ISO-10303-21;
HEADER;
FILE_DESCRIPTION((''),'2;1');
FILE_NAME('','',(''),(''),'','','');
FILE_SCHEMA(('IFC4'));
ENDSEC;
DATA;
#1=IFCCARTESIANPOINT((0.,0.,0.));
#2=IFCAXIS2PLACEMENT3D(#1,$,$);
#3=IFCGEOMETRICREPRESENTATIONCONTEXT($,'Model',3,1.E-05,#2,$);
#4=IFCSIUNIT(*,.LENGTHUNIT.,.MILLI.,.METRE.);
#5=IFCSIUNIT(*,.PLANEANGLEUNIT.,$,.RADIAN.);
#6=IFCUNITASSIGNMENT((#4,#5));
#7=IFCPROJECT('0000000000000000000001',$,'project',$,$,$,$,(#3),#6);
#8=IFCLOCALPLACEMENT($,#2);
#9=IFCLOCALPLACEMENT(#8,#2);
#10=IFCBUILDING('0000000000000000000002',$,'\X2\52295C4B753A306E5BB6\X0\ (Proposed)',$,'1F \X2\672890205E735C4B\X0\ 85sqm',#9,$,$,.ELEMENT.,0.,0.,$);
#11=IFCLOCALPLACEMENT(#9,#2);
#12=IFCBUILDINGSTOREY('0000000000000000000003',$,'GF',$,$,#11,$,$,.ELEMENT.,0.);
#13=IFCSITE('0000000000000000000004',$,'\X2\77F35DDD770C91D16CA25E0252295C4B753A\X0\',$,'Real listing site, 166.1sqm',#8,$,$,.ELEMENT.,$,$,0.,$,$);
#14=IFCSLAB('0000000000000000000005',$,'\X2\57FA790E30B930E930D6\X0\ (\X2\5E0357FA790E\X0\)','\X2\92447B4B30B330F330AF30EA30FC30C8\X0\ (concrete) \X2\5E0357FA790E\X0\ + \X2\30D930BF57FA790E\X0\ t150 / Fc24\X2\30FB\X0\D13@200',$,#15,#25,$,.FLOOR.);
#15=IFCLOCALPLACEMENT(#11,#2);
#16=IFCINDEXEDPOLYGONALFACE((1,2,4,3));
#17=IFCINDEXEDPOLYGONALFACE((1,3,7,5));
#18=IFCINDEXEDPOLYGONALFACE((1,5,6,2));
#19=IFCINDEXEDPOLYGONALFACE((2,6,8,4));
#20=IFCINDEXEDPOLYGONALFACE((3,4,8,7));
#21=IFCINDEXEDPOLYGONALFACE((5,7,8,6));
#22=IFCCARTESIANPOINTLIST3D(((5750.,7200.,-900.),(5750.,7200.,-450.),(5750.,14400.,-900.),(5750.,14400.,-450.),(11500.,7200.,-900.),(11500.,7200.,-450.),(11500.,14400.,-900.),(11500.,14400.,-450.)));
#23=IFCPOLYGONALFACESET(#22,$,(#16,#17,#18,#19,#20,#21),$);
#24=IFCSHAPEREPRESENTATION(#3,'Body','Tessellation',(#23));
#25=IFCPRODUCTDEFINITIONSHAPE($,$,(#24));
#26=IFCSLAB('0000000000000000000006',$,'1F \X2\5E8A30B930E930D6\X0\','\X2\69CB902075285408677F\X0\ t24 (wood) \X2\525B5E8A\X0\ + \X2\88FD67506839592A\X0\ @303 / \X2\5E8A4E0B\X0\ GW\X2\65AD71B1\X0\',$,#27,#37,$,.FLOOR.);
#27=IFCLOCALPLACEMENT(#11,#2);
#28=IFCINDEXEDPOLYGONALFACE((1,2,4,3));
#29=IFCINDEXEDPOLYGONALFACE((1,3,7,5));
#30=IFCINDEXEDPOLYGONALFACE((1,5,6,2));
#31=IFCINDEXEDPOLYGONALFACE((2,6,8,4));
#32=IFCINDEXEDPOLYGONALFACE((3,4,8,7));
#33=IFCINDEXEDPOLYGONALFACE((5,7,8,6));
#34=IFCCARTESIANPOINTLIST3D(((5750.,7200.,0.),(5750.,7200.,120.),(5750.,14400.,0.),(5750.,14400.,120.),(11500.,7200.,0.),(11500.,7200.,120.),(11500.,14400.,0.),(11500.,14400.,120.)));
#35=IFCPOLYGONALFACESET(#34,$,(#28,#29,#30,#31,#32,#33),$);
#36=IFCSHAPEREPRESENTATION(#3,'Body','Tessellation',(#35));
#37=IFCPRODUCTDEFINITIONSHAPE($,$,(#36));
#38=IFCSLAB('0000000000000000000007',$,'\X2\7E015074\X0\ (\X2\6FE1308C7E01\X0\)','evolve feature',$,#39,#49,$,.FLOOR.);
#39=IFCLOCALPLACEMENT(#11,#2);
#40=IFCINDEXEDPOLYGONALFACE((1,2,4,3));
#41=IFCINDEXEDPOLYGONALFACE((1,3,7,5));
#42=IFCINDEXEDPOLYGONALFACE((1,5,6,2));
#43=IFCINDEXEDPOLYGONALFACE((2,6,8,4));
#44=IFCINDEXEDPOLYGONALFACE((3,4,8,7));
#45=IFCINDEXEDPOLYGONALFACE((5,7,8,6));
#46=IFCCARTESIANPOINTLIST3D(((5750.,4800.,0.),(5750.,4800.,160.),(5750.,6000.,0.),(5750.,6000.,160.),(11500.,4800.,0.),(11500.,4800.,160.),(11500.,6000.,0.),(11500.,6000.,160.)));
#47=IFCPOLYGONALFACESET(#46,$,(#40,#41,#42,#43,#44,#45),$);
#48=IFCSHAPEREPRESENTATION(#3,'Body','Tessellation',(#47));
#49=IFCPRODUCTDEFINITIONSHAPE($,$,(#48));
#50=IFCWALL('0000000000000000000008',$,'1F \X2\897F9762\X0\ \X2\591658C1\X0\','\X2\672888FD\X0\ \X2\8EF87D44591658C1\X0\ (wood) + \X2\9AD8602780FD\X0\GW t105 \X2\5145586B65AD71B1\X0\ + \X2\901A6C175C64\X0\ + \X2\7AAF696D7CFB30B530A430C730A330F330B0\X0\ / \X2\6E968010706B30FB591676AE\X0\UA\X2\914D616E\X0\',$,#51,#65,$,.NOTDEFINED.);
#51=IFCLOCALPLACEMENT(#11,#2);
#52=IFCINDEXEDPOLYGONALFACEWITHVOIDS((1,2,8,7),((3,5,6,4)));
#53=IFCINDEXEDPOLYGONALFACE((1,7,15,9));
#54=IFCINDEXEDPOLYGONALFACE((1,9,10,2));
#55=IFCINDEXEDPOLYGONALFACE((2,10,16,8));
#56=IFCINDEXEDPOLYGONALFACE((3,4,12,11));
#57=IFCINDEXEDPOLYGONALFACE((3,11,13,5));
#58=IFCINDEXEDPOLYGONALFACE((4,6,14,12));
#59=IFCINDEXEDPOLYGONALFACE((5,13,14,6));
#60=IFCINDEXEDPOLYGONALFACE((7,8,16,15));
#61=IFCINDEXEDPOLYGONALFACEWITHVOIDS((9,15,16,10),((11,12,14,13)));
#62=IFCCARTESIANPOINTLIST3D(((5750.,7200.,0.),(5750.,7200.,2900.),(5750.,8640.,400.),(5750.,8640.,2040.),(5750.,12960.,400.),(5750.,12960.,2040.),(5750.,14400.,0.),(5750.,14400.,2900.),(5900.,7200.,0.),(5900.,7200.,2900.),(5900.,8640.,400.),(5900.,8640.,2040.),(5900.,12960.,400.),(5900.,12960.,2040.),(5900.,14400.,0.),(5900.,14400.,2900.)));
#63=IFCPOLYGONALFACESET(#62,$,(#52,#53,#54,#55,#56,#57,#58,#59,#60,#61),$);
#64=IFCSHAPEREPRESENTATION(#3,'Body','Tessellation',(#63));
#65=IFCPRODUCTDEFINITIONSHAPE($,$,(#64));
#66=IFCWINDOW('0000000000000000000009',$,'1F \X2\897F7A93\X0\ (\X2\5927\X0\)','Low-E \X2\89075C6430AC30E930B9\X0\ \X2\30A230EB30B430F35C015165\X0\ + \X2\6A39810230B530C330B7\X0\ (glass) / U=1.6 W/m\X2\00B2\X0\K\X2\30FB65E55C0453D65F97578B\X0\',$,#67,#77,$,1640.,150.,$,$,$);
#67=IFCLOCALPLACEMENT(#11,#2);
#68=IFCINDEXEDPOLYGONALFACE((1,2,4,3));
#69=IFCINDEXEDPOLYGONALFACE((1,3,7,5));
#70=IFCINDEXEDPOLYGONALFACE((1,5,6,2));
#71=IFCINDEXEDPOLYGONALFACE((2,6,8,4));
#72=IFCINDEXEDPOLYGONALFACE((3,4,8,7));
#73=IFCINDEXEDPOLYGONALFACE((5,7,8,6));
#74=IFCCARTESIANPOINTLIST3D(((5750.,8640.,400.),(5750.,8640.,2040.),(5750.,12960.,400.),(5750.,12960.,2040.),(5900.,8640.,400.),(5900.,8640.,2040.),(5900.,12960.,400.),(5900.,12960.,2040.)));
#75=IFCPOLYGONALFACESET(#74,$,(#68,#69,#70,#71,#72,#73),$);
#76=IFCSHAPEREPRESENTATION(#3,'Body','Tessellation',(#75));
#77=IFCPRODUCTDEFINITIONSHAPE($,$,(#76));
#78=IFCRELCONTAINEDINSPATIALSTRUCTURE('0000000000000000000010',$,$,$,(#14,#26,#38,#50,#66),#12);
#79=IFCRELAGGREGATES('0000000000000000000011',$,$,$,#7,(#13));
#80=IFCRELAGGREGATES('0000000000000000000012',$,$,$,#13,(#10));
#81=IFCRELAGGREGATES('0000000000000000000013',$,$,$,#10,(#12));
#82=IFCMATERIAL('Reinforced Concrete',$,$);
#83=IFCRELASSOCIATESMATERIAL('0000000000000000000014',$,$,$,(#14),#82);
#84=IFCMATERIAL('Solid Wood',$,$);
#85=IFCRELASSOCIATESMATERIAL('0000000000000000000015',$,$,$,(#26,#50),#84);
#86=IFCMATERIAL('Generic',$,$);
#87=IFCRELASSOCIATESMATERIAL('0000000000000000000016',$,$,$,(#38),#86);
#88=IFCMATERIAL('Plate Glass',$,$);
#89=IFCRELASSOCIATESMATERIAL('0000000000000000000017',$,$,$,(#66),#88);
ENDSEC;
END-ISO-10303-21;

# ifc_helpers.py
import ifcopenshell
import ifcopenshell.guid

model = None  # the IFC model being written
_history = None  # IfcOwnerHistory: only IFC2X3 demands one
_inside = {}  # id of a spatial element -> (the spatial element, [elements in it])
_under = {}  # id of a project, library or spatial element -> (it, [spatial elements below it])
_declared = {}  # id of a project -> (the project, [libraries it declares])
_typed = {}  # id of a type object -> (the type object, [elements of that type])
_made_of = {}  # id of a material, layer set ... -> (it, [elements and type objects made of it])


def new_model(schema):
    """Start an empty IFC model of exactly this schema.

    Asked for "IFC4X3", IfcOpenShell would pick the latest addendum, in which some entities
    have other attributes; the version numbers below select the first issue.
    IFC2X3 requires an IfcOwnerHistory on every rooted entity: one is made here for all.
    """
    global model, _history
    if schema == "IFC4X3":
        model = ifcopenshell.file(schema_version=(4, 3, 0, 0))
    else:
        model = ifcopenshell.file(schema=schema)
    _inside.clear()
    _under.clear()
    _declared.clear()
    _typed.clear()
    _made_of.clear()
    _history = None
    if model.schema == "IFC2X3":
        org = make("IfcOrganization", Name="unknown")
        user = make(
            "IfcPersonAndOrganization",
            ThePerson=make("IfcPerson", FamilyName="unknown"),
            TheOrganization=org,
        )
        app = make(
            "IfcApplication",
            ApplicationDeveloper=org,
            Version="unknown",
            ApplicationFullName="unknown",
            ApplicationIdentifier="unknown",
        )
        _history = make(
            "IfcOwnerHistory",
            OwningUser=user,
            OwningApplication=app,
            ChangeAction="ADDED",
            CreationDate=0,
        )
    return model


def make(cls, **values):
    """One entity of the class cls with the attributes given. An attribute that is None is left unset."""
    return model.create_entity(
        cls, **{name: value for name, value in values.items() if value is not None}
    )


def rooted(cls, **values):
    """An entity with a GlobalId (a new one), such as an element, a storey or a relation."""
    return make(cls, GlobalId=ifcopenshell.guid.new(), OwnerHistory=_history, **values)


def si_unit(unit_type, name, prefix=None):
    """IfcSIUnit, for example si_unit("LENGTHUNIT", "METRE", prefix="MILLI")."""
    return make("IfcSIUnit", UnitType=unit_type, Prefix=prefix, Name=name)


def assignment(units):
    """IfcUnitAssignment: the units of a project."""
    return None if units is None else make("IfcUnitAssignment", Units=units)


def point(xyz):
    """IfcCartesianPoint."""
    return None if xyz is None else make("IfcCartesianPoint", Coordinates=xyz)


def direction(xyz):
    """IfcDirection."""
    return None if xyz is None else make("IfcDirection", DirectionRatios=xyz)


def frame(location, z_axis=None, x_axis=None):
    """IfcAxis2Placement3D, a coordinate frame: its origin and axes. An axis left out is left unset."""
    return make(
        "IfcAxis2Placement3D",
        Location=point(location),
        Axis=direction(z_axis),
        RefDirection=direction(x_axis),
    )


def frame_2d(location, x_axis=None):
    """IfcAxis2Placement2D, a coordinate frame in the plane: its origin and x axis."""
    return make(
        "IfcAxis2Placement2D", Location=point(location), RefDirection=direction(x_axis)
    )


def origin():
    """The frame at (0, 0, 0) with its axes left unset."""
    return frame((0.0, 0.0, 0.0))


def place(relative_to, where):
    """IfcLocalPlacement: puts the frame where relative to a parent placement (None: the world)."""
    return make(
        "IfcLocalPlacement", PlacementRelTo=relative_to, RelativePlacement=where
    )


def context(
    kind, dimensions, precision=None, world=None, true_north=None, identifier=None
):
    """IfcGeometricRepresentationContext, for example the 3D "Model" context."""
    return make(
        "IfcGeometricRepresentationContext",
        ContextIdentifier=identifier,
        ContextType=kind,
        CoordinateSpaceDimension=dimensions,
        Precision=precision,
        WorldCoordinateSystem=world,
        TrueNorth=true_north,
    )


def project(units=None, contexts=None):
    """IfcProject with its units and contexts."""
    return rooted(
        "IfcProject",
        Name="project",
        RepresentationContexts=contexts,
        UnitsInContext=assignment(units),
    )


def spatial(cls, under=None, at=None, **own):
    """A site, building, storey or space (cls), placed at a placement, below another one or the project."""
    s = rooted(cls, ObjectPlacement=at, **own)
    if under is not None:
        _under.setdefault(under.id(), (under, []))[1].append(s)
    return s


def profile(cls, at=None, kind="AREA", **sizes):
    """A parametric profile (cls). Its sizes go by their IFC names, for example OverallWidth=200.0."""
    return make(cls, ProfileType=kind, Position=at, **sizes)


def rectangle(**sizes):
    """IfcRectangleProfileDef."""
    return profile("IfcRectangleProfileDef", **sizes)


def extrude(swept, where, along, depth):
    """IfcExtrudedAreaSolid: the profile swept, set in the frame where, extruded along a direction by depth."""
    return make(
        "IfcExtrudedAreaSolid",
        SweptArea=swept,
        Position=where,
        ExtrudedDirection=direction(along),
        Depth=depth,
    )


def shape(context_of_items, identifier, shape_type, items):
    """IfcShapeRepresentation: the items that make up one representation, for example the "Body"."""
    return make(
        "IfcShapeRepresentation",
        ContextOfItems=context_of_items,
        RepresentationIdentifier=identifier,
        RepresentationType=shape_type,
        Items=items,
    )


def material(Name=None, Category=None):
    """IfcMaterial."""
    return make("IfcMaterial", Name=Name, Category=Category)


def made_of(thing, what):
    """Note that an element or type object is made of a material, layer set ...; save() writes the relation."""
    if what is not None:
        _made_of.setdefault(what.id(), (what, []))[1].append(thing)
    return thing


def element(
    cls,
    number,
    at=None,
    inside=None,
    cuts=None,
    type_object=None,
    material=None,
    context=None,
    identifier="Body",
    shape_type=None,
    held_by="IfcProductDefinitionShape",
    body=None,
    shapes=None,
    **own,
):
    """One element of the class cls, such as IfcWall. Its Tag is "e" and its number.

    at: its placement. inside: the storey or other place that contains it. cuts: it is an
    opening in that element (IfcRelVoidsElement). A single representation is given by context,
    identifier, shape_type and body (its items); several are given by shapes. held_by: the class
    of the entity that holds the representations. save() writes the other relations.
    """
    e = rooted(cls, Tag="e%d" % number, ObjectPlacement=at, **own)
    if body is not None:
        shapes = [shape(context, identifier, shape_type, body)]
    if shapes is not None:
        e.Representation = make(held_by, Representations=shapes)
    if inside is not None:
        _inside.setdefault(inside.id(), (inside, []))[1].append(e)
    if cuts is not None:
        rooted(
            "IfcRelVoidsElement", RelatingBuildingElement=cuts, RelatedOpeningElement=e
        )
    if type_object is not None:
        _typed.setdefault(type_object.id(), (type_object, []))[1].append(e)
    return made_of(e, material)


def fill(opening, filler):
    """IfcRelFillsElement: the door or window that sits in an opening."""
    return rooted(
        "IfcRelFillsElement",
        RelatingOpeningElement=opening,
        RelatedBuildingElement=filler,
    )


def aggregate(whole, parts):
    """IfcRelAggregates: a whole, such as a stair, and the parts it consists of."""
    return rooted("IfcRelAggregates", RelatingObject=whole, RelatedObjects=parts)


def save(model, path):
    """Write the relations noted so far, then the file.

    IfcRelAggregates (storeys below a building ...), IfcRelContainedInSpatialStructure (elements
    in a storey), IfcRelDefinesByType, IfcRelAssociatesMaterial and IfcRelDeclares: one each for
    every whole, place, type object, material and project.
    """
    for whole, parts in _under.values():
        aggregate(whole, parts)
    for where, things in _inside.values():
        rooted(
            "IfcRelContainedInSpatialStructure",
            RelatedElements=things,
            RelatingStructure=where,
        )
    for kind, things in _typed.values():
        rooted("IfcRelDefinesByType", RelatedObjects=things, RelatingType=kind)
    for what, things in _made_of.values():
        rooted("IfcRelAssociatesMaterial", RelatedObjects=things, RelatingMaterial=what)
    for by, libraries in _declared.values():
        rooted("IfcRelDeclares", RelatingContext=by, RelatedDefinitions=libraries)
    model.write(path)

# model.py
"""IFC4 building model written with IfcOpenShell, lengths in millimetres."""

from ifc_helpers import new_model, si_unit, frame, frame_2d, origin, place, context, project, spatial, rectangle, extrude, material, element, fill, save


model = new_model("IFC4")

# Units and contexts
model_context = context("Model", 3, precision=1e-05, world=origin())
ifc_project = project(units=[si_unit("LENGTHUNIT", "METRE", prefix="MILLI"), si_unit("PLANEANGLEUNIT", "RADIAN")], contexts=[model_context])

# Site, building, storey
site_placement = place(None, origin())
site = spatial("IfcSite", under=ifc_project, at=site_placement, Name="石川県金沢市利屋町", ObjectType="Real listing site, 166.1sqm", CompositionType="ELEMENT", RefElevation=0.0)
building_placement = place(site_placement, origin())
building = spatial("IfcBuilding", under=site, at=building_placement, Name="利屋町の家 (Proposed)", ObjectType="1F 木造平屋 85sqm", CompositionType="ELEMENT", ElevationOfRefHeight=0.0, ElevationOfTerrain=0.0)
storey_placement = place(building_placement, origin())
storey = spatial("IfcBuildingStorey", under=building, at=storey_placement, Name="GF", CompositionType="ELEMENT", Elevation=0.0)

# Slabs
ifc_material_1 = material(Name="Reinforced Concrete")
slab_1_placement = place(storey_placement, frame((2875.0, 3600.0, -450.0)))
element("IfcSlab", 1, at=slab_1_placement, inside=storey, material=ifc_material_1, Name="基礎スラブ (布基礎)", Description="鉄筋コンクリート (concrete) 布基礎 + ベタ基礎 t150 / Fc24・D13@200", PredefinedType="FLOOR", context=model_context, shape_type="SweptSolid", body=[
    extrude(rectangle(XDim=5750.0, YDim=7200.0, at=frame_2d((2875.0, 3600.0))), frame((2875.0, 3600.0, -450.0)), (0.0, 0.0, 1.0), 450.0),
])
ifc_material_2 = material(Name="Solid Wood")
slab_2_placement = place(storey_placement, frame((2875.0, 3600.0, 0.0)))
element("IfcSlab", 2, at=slab_2_placement, inside=storey, material=ifc_material_2, Name="1F 床スラブ", Description="構造用合板 t24 (wood) 剛床 + 製材根太 @303 / 床下 GW断熱", PredefinedType="FLOOR", context=model_context, shape_type="SweptSolid", body=[
    extrude(rectangle(XDim=5750.0, YDim=7200.0, at=frame_2d((2875.0, 3600.0))), frame((2875.0, 3600.0, 0.0)), (0.0, 0.0, 1.0), 120.0),
])
ifc_material_3 = material(Name="Generic")
slab_3_placement = place(storey_placement, frame((2875.0, 2400.0, 0.0)))
element("IfcSlab", 3, at=slab_3_placement, inside=storey, material=ifc_material_3, Name="縁側 (濡れ縁)", Description="evolve feature", PredefinedType="FLOOR", context=model_context, shape_type="SweptSolid", body=[
    extrude(rectangle(XDim=5750.0, YDim=1200.0, at=frame_2d((2875.0, 600.0))), frame((2875.0, 2400.0, 0.0)), (0.0, 0.0, 1.0), 160.0),
])

# Shared definitions
ifc_material_4 = material(Name="Plate Glass")

# Wall, opening, window
wall_1_placement = place(storey_placement, frame((2875.0, 3600.0, 0.0)))
wall_1 = element("IfcWall", 4, at=wall_1_placement, inside=storey, material=ifc_material_2, Name="1F 西面 外壁", Description="木製 軸組外壁 (wood) + 高性能GW t105 充填断熱 + 通気層 + 窯業系サイディング / 準耐火・外皮UA配慮", PredefinedType="NOTDEFINED", context=model_context, shape_type="SweptSolid", body=[
    extrude(rectangle(XDim=150.0, YDim=7200.0, at=frame_2d((75.0, 3600.0))), frame((2875.0, 3600.0, 0.0)), (0.0, 0.0, 1.0), 2900.0),
])
opening_1_placement = place(storey_placement, frame((2875.0, 4320.0, 200.0)))
opening_1 = element("IfcOpeningElement", 5, at=opening_1_placement, cuts=wall_1, PredefinedType="NOTDEFINED", context=model_context, shape_type="SweptSolid", body=[
    extrude(rectangle(XDim=150.0, YDim=4320.0, at=frame_2d((75.0, 2160.0))), frame((2875.0, 4320.0, 200.0)), (0.0, 0.0, 1.0), 1640.0),
])
window_1_placement = place(storey_placement, frame((2875.0, 4320.0, 200.0)))
window_1 = element("IfcWindow", 6, at=window_1_placement, inside=storey, material=ifc_material_4, Name="1F 西窓 (大)", Description="Low-E 複層ガラス アルゴン封入 + 樹脂サッシ (glass) / U=1.6 W/m²K・日射取得型", OverallHeight=1640.0, OverallWidth=150.0, context=model_context, shape_type="SweptSolid", body=[
    extrude(rectangle(XDim=150.0, YDim=4320.0, at=frame_2d((75.0, 2160.0))), frame((2875.0, 4320.0, 200.0)), (0.0, 0.0, 1.0), 1640.0),
])
fill(opening_1, window_1)

save(model, "model.ifc")
